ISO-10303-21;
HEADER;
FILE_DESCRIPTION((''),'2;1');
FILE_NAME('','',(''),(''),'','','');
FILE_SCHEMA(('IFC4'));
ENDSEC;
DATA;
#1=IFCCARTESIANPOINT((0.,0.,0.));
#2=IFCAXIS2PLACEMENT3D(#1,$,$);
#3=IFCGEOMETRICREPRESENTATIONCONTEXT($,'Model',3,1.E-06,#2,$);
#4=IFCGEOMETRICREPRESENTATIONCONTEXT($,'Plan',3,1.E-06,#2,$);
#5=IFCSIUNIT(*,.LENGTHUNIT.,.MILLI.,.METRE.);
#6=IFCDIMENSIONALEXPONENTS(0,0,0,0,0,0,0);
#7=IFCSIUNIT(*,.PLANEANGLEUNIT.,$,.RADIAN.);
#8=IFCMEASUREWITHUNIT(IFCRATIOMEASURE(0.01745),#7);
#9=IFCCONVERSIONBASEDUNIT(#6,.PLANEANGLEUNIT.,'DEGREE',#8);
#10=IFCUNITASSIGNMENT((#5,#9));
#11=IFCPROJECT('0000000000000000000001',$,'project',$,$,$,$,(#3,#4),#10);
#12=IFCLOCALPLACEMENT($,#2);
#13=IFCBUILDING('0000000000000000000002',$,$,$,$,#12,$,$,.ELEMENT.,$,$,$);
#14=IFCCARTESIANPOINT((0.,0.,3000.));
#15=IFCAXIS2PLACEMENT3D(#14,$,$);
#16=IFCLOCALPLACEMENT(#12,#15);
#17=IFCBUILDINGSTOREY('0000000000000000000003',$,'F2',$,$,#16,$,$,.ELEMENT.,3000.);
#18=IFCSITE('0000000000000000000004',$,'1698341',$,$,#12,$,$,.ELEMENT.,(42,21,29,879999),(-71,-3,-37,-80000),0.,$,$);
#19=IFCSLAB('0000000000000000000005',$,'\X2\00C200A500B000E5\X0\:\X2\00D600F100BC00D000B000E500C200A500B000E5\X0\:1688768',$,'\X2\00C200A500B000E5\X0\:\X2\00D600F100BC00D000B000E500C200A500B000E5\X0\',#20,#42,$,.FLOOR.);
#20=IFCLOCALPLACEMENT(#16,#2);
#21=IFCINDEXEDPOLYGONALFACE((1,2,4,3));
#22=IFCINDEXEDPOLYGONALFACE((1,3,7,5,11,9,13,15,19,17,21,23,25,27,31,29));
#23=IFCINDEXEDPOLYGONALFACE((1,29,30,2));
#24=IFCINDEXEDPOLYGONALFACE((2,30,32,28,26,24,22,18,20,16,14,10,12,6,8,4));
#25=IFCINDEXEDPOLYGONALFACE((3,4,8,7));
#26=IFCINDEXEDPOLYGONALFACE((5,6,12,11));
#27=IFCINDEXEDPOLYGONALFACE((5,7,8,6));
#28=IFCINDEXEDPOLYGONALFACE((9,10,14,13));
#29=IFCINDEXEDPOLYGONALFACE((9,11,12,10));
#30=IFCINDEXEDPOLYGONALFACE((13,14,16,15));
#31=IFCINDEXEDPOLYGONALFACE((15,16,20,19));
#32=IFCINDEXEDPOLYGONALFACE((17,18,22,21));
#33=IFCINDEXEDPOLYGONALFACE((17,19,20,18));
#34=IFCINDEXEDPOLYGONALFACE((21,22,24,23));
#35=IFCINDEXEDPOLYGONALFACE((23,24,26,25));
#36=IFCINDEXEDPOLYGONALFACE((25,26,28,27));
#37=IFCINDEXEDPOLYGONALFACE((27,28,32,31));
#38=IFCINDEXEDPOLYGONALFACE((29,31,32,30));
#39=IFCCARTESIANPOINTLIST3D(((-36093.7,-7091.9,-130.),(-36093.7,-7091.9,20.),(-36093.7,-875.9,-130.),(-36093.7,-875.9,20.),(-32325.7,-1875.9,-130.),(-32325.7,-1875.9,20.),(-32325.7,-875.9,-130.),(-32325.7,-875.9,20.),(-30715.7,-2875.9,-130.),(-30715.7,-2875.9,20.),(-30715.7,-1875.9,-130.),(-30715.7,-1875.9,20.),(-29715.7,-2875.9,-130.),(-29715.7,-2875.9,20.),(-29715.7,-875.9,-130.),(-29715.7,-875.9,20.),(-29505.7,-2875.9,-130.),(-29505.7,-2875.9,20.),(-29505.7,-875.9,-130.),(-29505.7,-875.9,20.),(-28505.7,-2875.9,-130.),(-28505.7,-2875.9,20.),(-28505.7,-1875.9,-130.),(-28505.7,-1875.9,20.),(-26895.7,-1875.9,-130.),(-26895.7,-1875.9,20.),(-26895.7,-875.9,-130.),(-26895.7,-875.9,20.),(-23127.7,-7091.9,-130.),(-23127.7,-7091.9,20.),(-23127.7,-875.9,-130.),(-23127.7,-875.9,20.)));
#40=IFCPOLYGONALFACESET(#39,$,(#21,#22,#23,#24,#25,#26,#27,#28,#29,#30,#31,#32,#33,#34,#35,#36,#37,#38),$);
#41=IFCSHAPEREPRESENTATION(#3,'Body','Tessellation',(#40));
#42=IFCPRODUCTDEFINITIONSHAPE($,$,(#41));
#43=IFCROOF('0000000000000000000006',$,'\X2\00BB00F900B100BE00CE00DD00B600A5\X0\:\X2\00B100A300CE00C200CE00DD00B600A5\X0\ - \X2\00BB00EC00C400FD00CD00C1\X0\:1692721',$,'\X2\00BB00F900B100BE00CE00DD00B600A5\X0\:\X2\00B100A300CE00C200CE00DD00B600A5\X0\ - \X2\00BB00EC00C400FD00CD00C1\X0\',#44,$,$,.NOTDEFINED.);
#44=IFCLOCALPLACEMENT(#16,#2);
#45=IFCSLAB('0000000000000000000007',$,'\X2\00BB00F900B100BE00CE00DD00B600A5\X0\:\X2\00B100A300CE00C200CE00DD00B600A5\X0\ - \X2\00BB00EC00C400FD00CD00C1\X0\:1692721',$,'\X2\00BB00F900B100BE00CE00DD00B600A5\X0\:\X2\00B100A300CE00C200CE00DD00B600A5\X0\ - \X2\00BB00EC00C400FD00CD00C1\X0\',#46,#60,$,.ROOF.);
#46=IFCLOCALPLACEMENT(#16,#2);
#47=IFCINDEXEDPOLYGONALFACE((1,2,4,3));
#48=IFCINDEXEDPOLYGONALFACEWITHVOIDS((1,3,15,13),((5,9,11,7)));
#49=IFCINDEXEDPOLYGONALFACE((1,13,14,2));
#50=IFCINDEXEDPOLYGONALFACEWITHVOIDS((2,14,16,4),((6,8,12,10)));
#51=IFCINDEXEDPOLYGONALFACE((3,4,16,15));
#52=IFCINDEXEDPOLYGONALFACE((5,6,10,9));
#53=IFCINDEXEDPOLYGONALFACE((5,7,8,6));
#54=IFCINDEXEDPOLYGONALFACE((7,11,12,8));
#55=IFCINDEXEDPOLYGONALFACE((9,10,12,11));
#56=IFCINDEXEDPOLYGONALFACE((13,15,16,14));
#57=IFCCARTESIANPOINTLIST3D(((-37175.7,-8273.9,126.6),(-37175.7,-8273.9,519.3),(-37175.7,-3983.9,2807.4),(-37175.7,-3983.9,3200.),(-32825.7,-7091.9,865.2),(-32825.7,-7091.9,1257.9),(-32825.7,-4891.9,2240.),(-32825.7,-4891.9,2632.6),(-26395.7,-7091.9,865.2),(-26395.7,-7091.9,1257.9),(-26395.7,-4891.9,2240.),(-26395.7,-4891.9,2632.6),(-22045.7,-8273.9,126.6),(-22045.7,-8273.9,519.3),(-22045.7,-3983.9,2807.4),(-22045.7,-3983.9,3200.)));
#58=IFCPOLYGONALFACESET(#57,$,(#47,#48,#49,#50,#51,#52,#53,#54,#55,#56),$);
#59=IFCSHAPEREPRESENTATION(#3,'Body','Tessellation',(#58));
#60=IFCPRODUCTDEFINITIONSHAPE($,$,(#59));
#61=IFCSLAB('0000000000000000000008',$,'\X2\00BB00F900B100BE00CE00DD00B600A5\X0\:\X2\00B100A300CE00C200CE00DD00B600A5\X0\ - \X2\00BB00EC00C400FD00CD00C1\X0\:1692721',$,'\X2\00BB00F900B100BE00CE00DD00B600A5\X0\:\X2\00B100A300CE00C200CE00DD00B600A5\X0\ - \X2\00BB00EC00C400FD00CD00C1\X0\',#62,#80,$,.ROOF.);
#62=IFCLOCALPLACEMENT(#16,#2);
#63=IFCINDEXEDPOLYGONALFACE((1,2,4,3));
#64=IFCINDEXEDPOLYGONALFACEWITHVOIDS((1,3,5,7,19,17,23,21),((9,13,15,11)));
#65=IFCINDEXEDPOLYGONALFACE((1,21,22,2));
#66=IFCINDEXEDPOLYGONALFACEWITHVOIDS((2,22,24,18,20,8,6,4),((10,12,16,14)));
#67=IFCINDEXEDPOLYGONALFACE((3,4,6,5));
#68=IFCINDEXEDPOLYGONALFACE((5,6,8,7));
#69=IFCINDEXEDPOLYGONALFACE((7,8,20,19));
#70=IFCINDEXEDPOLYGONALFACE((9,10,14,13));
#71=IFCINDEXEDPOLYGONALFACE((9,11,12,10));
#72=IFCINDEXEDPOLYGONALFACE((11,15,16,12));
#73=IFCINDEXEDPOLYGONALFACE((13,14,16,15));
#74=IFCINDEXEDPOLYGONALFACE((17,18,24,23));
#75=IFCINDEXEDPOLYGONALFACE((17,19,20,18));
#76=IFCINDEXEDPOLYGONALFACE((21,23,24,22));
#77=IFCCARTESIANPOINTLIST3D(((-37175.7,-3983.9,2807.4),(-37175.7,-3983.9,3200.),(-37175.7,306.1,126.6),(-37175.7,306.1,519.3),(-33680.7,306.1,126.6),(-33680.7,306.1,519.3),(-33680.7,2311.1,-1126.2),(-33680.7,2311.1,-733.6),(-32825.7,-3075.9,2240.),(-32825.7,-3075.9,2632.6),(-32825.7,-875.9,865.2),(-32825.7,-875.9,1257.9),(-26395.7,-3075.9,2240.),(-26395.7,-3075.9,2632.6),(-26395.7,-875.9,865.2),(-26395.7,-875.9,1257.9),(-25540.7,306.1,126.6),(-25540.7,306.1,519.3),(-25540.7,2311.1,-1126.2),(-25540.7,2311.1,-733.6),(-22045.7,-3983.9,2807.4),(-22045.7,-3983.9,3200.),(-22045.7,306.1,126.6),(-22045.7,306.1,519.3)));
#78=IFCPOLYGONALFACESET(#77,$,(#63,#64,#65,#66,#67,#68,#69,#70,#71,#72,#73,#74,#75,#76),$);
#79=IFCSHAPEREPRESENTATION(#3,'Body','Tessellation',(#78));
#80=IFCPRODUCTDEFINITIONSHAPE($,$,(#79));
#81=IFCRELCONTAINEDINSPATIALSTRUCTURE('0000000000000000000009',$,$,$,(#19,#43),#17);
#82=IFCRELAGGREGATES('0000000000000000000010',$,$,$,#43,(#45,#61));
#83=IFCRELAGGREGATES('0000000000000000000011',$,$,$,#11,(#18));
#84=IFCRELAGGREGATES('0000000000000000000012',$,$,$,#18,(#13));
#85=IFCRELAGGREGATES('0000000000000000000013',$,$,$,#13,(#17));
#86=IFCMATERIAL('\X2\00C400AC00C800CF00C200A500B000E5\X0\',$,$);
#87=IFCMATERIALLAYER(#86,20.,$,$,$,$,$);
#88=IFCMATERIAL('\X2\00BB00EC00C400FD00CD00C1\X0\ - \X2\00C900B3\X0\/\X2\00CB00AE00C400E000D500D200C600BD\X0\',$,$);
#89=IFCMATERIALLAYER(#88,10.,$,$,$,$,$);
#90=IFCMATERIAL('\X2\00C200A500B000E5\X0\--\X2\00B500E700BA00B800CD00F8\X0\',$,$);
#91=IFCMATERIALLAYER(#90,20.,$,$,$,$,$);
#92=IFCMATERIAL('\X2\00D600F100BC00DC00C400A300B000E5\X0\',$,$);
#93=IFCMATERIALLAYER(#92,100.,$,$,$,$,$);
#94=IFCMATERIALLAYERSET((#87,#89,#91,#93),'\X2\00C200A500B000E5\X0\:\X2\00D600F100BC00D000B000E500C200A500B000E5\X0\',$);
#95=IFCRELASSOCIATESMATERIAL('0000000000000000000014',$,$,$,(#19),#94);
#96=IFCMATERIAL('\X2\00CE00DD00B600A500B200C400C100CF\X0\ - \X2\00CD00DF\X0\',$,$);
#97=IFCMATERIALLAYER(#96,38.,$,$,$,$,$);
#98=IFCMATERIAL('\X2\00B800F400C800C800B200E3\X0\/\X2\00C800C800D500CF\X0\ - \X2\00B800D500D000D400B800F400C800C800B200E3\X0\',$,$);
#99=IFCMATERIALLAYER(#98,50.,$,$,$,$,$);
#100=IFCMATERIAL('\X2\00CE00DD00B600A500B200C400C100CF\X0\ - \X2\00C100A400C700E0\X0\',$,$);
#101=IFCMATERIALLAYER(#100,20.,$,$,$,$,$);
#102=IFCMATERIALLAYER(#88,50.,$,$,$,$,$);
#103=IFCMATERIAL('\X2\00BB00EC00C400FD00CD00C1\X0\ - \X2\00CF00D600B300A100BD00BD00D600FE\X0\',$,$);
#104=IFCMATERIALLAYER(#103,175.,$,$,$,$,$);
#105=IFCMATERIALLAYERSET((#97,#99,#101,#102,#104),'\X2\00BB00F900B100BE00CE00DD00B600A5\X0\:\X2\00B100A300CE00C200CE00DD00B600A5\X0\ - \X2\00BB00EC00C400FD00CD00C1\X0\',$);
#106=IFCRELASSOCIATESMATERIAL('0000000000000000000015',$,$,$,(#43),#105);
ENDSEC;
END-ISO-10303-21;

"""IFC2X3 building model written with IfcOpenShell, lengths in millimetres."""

from ifc_helpers import new_model, entity, si_unit, converted_unit, frame, frame_2d, origin, origin_2d_with_axis, place, context, project, spatial, polyline, rectangle, outline, extrude, material, layer, layer_set, layer_usage, element, aggregate, save


model = new_model("IFC2X3")

# Units and contexts
model_context = context("Model", 3, precision=1e-06, world=origin())
plan_context = context("Plan", 3, precision=1e-06, world=origin())
ifc_project = project(units=[si_unit("LENGTHUNIT", "METRE", prefix="MILLI"), converted_unit("PLANEANGLEUNIT", "DEGREE", entity("IfcRatioMeasure", 0.01745), si_unit("PLANEANGLEUNIT", "RADIAN"), dimensions=[0, 0, 0, 0, 0, 0, 0])], contexts=[model_context, plan_context])

# Site, building, storey
placement_1 = place(None, origin())
site = spatial("IfcSite", under=ifc_project, at=placement_1, Name="1698341", CompositionType="ELEMENT", RefLatitude=(42, 21, 29, 879999), RefLongitude=(-71, -3, -37, -80000), RefElevation=0.0)
building = spatial("IfcBuilding", under=site, at=placement_1, CompositionType="ELEMENT")
storey_placement = place(placement_1, frame((0.0, 0.0, 3000.0)))
storey = spatial("IfcBuildingStorey", under=building, at=storey_placement, Name="F2", CompositionType="ELEMENT", Elevation=3000.0)

# Slab, openings
ifc_material_1 = material(Name="Ä¬ÈÏÂ¥°å")
ifc_layer_1 = layer(ifc_material_1, 20.0)
ifc_material_2 = material(Name="»ìÄýÍÁ - É³/Ë®ÄàÕÒÆ½")
ifc_layer_2 = layer(ifc_material_2, 10.0)
ifc_material_3 = material(Name="Â¥°å--µçº¸Íø")
ifc_layer_3 = layer(ifc_material_3, 20.0)
ifc_material_4 = material(Name="Öñ¼ÜÄ£°å")
ifc_layer_4 = layer(ifc_material_4, 100.0)
ifc_layer_set_1 = layer_set([ifc_layer_1, ifc_layer_2, ifc_layer_3, ifc_layer_4], Name="Â¥°å:Öñ¼Ð°åÂ¥°å")
ifc_layer_usage_1 = layer_usage(ifc_layer_set_1, "AXIS3", "POSITIVE", 0.0)
placement_2 = place(storey_placement, frame((-36093.7, -7091.9, -130.0)))
slab_1 = element("IfcSlab", 1, at=placement_2, inside=storey, material=ifc_layer_usage_1, Name="Â¥°å:Öñ¼Ð°åÂ¥°å:1688768", ObjectType="Â¥°å:Öñ¼Ð°åÂ¥°å", PredefinedType="FLOOR", context=model_context, shape_type="SweptSolid", body=[
    extrude(rectangle(XDim=6216.0, YDim=12966.0, at=frame_2d((0.0, 0.0), x_axis=(0.0, -1.0))), frame((6483.0, 3108.0, 150.0), z_axis=(0.0, 0.0, -1.0), x_axis=(-1.0, 0.0, 0.0)), (0.0, 0.0, 1.0), 150.0),
])
element("IfcOpeningElement", 2, at=placement_2, cuts=slab_1, ObjectType="Opening", context=model_context, shape_type="SweptSolid", body=[
    extrude(outline(polyline([(2715.0, 3108.0), (105.0, 3108.0), (105.0, 1108.0), (1105.0, 1108.0), (1105.0, 2108.0), (2715.0, 2108.0), (2715.0, 3108.0)])), frame((6483.0, 3108.0, 150.0), z_axis=(0.0, 0.0, -1.0), x_axis=(-1.0, 0.0, 0.0)), (0.0, 0.0, 1.0), 150.0),
])
element("IfcOpeningElement", 3, at=placement_2, cuts=slab_1, ObjectType="Opening", context=model_context, shape_type="SweptSolid", body=[
    extrude(outline(polyline([(-2715.0, 3108.0), (-2715.0, 2108.0), (-1105.0, 2108.0), (-1105.0, 1108.0), (-105.0, 1108.0), (-105.0, 3108.0), (-2715.0, 3108.0)])), frame((6483.0, 3108.0, 150.0), z_axis=(0.0, 0.0, -1.0), x_axis=(-1.0, 0.0, 0.0)), (0.0, 0.0, 1.0), 150.0),
])

# Roof, slabs, openings
ifc_material_5 = material(Name="ÎÝ¶¥²ÄÁÏ - Íß")
ifc_layer_5 = layer(ifc_material_5, 38.0)
ifc_material_6 = material(Name="¸ôÈÈ²ã/ÈÈÕÏ - ¸ÕÐÔ¸ôÈÈ²ã")
ifc_layer_6 = layer(ifc_material_6, 50.0)
ifc_material_7 = material(Name="ÎÝ¶¥²ÄÁÏ - Á¤Çà")
ifc_layer_7 = layer(ifc_material_7, 20.0)
ifc_layer_8 = layer(ifc_material_2, 50.0)
ifc_material_8 = material(Name="»ìÄýÍÁ - ÏÖ³¡½½Öþ")
ifc_layer_9 = layer(ifc_material_8, 175.0)
ifc_layer_set_2 = layer_set([ifc_layer_5, ifc_layer_6, ifc_layer_7, ifc_layer_8, ifc_layer_9], Name="»ù±¾ÎÝ¶¥:±£ÎÂÎÝ¶¥ - »ìÄýÍÁ")
ifc_layer_usage_2 = layer_usage(ifc_layer_set_2, "AXIS3", "NEGATIVE", 0.0)
roof_placement = place(storey_placement, origin())
roof = element("IfcRoof", 4, at=roof_placement, inside=storey, material=ifc_layer_usage_2, Name="»ù±¾ÎÝ¶¥:±£ÎÂÎÝ¶¥ - »ìÄýÍÁ:1692721", ObjectType="»ù±¾ÎÝ¶¥:±£ÎÂÎÝ¶¥ - »ìÄýÍÁ", ShapeType="NOTDEFINED")
placement_3 = place(roof_placement, frame((-37175.7, -8273.9, -1126.2)))
slab_2 = element("IfcSlab", 5, at=placement_3, Name="»ù±¾ÎÝ¶¥:±£ÎÂÎÝ¶¥ - »ìÄýÍÁ:1692721", ObjectType="»ù±¾ÎÝ¶¥:±£ÎÂÎÝ¶¥ - »ìÄýÍÁ", PredefinedType="ROOF", context=model_context, shape_type="SweptSolid", body=[
    extrude(rectangle(XDim=5058.7, YDim=15130.0, at=frame_2d((0.0, 0.0), x_axis=(0.0, -1.0))), frame((7565.0, 2145.0, 2593.2), z_axis=(0.0, -0.5299, 0.848), x_axis=(1.0, 0.0, 0.0)), (0.0, 0.5299, 0.848), 392.7),
])
element("IfcOpeningElement", 6, at=placement_3, cuts=slab_2, ObjectType="Opening", context=model_context, shape_type="SweptSolid", body=[
    extrude(rectangle(XDim=2594.2, YDim=6430.0, at=frame_2d((0.0, 0.0), x_axis=(0.0, 1.0))), frame((7565.0, 2282.0, 2678.8), z_axis=(0.0, -0.5299, 0.848), x_axis=(-1.0, 0.0, 0.0)), (0.0, -0.5299, 0.848), 392.7),
])
slab_3 = element("IfcSlab", 7, at=placement_3, Name="»ù±¾ÎÝ¶¥:±£ÎÂÎÝ¶¥ - »ìÄýÍÁ:1692721", ObjectType="»ù±¾ÎÝ¶¥:±£ÎÂÎÝ¶¥ - »ìÄýÍÁ", PredefinedType="ROOF", context=model_context, shape_type="SweptSolid", body=[
    extrude(outline(polyline([(-7565.0, -3711.5), (7565.0, -3711.5), (7565.0, 1347.2), (4070.0, 1347.2), (4070.0, 3711.5), (-4070.0, 3711.5), (-4070.0, 1347.2), (-7565.0, 1347.2), (-7565.0, -3711.5)])), frame((7565.0, 7437.5, 1966.8), z_axis=(0.0, 0.5299, 0.848), x_axis=(1.0, 0.0, 0.0)), (0.0, -0.5299, 0.848), 392.7),
])
element("IfcOpeningElement", 8, at=placement_3, cuts=slab_3, ObjectType="Opening", context=model_context, shape_type="SweptSolid", body=[
    extrude(rectangle(XDim=2594.2, YDim=6430.0, at=origin_2d_with_axis()), frame((7565.0, 6298.0, 2678.8), z_axis=(0.0, 0.5299, 0.848), x_axis=(0.0, 0.848, -0.5299)), (-0.5299, 0.0, 0.848), 392.7),
])
aggregate(roof, [slab_2, slab_3])

save(model, "model.ifc")
